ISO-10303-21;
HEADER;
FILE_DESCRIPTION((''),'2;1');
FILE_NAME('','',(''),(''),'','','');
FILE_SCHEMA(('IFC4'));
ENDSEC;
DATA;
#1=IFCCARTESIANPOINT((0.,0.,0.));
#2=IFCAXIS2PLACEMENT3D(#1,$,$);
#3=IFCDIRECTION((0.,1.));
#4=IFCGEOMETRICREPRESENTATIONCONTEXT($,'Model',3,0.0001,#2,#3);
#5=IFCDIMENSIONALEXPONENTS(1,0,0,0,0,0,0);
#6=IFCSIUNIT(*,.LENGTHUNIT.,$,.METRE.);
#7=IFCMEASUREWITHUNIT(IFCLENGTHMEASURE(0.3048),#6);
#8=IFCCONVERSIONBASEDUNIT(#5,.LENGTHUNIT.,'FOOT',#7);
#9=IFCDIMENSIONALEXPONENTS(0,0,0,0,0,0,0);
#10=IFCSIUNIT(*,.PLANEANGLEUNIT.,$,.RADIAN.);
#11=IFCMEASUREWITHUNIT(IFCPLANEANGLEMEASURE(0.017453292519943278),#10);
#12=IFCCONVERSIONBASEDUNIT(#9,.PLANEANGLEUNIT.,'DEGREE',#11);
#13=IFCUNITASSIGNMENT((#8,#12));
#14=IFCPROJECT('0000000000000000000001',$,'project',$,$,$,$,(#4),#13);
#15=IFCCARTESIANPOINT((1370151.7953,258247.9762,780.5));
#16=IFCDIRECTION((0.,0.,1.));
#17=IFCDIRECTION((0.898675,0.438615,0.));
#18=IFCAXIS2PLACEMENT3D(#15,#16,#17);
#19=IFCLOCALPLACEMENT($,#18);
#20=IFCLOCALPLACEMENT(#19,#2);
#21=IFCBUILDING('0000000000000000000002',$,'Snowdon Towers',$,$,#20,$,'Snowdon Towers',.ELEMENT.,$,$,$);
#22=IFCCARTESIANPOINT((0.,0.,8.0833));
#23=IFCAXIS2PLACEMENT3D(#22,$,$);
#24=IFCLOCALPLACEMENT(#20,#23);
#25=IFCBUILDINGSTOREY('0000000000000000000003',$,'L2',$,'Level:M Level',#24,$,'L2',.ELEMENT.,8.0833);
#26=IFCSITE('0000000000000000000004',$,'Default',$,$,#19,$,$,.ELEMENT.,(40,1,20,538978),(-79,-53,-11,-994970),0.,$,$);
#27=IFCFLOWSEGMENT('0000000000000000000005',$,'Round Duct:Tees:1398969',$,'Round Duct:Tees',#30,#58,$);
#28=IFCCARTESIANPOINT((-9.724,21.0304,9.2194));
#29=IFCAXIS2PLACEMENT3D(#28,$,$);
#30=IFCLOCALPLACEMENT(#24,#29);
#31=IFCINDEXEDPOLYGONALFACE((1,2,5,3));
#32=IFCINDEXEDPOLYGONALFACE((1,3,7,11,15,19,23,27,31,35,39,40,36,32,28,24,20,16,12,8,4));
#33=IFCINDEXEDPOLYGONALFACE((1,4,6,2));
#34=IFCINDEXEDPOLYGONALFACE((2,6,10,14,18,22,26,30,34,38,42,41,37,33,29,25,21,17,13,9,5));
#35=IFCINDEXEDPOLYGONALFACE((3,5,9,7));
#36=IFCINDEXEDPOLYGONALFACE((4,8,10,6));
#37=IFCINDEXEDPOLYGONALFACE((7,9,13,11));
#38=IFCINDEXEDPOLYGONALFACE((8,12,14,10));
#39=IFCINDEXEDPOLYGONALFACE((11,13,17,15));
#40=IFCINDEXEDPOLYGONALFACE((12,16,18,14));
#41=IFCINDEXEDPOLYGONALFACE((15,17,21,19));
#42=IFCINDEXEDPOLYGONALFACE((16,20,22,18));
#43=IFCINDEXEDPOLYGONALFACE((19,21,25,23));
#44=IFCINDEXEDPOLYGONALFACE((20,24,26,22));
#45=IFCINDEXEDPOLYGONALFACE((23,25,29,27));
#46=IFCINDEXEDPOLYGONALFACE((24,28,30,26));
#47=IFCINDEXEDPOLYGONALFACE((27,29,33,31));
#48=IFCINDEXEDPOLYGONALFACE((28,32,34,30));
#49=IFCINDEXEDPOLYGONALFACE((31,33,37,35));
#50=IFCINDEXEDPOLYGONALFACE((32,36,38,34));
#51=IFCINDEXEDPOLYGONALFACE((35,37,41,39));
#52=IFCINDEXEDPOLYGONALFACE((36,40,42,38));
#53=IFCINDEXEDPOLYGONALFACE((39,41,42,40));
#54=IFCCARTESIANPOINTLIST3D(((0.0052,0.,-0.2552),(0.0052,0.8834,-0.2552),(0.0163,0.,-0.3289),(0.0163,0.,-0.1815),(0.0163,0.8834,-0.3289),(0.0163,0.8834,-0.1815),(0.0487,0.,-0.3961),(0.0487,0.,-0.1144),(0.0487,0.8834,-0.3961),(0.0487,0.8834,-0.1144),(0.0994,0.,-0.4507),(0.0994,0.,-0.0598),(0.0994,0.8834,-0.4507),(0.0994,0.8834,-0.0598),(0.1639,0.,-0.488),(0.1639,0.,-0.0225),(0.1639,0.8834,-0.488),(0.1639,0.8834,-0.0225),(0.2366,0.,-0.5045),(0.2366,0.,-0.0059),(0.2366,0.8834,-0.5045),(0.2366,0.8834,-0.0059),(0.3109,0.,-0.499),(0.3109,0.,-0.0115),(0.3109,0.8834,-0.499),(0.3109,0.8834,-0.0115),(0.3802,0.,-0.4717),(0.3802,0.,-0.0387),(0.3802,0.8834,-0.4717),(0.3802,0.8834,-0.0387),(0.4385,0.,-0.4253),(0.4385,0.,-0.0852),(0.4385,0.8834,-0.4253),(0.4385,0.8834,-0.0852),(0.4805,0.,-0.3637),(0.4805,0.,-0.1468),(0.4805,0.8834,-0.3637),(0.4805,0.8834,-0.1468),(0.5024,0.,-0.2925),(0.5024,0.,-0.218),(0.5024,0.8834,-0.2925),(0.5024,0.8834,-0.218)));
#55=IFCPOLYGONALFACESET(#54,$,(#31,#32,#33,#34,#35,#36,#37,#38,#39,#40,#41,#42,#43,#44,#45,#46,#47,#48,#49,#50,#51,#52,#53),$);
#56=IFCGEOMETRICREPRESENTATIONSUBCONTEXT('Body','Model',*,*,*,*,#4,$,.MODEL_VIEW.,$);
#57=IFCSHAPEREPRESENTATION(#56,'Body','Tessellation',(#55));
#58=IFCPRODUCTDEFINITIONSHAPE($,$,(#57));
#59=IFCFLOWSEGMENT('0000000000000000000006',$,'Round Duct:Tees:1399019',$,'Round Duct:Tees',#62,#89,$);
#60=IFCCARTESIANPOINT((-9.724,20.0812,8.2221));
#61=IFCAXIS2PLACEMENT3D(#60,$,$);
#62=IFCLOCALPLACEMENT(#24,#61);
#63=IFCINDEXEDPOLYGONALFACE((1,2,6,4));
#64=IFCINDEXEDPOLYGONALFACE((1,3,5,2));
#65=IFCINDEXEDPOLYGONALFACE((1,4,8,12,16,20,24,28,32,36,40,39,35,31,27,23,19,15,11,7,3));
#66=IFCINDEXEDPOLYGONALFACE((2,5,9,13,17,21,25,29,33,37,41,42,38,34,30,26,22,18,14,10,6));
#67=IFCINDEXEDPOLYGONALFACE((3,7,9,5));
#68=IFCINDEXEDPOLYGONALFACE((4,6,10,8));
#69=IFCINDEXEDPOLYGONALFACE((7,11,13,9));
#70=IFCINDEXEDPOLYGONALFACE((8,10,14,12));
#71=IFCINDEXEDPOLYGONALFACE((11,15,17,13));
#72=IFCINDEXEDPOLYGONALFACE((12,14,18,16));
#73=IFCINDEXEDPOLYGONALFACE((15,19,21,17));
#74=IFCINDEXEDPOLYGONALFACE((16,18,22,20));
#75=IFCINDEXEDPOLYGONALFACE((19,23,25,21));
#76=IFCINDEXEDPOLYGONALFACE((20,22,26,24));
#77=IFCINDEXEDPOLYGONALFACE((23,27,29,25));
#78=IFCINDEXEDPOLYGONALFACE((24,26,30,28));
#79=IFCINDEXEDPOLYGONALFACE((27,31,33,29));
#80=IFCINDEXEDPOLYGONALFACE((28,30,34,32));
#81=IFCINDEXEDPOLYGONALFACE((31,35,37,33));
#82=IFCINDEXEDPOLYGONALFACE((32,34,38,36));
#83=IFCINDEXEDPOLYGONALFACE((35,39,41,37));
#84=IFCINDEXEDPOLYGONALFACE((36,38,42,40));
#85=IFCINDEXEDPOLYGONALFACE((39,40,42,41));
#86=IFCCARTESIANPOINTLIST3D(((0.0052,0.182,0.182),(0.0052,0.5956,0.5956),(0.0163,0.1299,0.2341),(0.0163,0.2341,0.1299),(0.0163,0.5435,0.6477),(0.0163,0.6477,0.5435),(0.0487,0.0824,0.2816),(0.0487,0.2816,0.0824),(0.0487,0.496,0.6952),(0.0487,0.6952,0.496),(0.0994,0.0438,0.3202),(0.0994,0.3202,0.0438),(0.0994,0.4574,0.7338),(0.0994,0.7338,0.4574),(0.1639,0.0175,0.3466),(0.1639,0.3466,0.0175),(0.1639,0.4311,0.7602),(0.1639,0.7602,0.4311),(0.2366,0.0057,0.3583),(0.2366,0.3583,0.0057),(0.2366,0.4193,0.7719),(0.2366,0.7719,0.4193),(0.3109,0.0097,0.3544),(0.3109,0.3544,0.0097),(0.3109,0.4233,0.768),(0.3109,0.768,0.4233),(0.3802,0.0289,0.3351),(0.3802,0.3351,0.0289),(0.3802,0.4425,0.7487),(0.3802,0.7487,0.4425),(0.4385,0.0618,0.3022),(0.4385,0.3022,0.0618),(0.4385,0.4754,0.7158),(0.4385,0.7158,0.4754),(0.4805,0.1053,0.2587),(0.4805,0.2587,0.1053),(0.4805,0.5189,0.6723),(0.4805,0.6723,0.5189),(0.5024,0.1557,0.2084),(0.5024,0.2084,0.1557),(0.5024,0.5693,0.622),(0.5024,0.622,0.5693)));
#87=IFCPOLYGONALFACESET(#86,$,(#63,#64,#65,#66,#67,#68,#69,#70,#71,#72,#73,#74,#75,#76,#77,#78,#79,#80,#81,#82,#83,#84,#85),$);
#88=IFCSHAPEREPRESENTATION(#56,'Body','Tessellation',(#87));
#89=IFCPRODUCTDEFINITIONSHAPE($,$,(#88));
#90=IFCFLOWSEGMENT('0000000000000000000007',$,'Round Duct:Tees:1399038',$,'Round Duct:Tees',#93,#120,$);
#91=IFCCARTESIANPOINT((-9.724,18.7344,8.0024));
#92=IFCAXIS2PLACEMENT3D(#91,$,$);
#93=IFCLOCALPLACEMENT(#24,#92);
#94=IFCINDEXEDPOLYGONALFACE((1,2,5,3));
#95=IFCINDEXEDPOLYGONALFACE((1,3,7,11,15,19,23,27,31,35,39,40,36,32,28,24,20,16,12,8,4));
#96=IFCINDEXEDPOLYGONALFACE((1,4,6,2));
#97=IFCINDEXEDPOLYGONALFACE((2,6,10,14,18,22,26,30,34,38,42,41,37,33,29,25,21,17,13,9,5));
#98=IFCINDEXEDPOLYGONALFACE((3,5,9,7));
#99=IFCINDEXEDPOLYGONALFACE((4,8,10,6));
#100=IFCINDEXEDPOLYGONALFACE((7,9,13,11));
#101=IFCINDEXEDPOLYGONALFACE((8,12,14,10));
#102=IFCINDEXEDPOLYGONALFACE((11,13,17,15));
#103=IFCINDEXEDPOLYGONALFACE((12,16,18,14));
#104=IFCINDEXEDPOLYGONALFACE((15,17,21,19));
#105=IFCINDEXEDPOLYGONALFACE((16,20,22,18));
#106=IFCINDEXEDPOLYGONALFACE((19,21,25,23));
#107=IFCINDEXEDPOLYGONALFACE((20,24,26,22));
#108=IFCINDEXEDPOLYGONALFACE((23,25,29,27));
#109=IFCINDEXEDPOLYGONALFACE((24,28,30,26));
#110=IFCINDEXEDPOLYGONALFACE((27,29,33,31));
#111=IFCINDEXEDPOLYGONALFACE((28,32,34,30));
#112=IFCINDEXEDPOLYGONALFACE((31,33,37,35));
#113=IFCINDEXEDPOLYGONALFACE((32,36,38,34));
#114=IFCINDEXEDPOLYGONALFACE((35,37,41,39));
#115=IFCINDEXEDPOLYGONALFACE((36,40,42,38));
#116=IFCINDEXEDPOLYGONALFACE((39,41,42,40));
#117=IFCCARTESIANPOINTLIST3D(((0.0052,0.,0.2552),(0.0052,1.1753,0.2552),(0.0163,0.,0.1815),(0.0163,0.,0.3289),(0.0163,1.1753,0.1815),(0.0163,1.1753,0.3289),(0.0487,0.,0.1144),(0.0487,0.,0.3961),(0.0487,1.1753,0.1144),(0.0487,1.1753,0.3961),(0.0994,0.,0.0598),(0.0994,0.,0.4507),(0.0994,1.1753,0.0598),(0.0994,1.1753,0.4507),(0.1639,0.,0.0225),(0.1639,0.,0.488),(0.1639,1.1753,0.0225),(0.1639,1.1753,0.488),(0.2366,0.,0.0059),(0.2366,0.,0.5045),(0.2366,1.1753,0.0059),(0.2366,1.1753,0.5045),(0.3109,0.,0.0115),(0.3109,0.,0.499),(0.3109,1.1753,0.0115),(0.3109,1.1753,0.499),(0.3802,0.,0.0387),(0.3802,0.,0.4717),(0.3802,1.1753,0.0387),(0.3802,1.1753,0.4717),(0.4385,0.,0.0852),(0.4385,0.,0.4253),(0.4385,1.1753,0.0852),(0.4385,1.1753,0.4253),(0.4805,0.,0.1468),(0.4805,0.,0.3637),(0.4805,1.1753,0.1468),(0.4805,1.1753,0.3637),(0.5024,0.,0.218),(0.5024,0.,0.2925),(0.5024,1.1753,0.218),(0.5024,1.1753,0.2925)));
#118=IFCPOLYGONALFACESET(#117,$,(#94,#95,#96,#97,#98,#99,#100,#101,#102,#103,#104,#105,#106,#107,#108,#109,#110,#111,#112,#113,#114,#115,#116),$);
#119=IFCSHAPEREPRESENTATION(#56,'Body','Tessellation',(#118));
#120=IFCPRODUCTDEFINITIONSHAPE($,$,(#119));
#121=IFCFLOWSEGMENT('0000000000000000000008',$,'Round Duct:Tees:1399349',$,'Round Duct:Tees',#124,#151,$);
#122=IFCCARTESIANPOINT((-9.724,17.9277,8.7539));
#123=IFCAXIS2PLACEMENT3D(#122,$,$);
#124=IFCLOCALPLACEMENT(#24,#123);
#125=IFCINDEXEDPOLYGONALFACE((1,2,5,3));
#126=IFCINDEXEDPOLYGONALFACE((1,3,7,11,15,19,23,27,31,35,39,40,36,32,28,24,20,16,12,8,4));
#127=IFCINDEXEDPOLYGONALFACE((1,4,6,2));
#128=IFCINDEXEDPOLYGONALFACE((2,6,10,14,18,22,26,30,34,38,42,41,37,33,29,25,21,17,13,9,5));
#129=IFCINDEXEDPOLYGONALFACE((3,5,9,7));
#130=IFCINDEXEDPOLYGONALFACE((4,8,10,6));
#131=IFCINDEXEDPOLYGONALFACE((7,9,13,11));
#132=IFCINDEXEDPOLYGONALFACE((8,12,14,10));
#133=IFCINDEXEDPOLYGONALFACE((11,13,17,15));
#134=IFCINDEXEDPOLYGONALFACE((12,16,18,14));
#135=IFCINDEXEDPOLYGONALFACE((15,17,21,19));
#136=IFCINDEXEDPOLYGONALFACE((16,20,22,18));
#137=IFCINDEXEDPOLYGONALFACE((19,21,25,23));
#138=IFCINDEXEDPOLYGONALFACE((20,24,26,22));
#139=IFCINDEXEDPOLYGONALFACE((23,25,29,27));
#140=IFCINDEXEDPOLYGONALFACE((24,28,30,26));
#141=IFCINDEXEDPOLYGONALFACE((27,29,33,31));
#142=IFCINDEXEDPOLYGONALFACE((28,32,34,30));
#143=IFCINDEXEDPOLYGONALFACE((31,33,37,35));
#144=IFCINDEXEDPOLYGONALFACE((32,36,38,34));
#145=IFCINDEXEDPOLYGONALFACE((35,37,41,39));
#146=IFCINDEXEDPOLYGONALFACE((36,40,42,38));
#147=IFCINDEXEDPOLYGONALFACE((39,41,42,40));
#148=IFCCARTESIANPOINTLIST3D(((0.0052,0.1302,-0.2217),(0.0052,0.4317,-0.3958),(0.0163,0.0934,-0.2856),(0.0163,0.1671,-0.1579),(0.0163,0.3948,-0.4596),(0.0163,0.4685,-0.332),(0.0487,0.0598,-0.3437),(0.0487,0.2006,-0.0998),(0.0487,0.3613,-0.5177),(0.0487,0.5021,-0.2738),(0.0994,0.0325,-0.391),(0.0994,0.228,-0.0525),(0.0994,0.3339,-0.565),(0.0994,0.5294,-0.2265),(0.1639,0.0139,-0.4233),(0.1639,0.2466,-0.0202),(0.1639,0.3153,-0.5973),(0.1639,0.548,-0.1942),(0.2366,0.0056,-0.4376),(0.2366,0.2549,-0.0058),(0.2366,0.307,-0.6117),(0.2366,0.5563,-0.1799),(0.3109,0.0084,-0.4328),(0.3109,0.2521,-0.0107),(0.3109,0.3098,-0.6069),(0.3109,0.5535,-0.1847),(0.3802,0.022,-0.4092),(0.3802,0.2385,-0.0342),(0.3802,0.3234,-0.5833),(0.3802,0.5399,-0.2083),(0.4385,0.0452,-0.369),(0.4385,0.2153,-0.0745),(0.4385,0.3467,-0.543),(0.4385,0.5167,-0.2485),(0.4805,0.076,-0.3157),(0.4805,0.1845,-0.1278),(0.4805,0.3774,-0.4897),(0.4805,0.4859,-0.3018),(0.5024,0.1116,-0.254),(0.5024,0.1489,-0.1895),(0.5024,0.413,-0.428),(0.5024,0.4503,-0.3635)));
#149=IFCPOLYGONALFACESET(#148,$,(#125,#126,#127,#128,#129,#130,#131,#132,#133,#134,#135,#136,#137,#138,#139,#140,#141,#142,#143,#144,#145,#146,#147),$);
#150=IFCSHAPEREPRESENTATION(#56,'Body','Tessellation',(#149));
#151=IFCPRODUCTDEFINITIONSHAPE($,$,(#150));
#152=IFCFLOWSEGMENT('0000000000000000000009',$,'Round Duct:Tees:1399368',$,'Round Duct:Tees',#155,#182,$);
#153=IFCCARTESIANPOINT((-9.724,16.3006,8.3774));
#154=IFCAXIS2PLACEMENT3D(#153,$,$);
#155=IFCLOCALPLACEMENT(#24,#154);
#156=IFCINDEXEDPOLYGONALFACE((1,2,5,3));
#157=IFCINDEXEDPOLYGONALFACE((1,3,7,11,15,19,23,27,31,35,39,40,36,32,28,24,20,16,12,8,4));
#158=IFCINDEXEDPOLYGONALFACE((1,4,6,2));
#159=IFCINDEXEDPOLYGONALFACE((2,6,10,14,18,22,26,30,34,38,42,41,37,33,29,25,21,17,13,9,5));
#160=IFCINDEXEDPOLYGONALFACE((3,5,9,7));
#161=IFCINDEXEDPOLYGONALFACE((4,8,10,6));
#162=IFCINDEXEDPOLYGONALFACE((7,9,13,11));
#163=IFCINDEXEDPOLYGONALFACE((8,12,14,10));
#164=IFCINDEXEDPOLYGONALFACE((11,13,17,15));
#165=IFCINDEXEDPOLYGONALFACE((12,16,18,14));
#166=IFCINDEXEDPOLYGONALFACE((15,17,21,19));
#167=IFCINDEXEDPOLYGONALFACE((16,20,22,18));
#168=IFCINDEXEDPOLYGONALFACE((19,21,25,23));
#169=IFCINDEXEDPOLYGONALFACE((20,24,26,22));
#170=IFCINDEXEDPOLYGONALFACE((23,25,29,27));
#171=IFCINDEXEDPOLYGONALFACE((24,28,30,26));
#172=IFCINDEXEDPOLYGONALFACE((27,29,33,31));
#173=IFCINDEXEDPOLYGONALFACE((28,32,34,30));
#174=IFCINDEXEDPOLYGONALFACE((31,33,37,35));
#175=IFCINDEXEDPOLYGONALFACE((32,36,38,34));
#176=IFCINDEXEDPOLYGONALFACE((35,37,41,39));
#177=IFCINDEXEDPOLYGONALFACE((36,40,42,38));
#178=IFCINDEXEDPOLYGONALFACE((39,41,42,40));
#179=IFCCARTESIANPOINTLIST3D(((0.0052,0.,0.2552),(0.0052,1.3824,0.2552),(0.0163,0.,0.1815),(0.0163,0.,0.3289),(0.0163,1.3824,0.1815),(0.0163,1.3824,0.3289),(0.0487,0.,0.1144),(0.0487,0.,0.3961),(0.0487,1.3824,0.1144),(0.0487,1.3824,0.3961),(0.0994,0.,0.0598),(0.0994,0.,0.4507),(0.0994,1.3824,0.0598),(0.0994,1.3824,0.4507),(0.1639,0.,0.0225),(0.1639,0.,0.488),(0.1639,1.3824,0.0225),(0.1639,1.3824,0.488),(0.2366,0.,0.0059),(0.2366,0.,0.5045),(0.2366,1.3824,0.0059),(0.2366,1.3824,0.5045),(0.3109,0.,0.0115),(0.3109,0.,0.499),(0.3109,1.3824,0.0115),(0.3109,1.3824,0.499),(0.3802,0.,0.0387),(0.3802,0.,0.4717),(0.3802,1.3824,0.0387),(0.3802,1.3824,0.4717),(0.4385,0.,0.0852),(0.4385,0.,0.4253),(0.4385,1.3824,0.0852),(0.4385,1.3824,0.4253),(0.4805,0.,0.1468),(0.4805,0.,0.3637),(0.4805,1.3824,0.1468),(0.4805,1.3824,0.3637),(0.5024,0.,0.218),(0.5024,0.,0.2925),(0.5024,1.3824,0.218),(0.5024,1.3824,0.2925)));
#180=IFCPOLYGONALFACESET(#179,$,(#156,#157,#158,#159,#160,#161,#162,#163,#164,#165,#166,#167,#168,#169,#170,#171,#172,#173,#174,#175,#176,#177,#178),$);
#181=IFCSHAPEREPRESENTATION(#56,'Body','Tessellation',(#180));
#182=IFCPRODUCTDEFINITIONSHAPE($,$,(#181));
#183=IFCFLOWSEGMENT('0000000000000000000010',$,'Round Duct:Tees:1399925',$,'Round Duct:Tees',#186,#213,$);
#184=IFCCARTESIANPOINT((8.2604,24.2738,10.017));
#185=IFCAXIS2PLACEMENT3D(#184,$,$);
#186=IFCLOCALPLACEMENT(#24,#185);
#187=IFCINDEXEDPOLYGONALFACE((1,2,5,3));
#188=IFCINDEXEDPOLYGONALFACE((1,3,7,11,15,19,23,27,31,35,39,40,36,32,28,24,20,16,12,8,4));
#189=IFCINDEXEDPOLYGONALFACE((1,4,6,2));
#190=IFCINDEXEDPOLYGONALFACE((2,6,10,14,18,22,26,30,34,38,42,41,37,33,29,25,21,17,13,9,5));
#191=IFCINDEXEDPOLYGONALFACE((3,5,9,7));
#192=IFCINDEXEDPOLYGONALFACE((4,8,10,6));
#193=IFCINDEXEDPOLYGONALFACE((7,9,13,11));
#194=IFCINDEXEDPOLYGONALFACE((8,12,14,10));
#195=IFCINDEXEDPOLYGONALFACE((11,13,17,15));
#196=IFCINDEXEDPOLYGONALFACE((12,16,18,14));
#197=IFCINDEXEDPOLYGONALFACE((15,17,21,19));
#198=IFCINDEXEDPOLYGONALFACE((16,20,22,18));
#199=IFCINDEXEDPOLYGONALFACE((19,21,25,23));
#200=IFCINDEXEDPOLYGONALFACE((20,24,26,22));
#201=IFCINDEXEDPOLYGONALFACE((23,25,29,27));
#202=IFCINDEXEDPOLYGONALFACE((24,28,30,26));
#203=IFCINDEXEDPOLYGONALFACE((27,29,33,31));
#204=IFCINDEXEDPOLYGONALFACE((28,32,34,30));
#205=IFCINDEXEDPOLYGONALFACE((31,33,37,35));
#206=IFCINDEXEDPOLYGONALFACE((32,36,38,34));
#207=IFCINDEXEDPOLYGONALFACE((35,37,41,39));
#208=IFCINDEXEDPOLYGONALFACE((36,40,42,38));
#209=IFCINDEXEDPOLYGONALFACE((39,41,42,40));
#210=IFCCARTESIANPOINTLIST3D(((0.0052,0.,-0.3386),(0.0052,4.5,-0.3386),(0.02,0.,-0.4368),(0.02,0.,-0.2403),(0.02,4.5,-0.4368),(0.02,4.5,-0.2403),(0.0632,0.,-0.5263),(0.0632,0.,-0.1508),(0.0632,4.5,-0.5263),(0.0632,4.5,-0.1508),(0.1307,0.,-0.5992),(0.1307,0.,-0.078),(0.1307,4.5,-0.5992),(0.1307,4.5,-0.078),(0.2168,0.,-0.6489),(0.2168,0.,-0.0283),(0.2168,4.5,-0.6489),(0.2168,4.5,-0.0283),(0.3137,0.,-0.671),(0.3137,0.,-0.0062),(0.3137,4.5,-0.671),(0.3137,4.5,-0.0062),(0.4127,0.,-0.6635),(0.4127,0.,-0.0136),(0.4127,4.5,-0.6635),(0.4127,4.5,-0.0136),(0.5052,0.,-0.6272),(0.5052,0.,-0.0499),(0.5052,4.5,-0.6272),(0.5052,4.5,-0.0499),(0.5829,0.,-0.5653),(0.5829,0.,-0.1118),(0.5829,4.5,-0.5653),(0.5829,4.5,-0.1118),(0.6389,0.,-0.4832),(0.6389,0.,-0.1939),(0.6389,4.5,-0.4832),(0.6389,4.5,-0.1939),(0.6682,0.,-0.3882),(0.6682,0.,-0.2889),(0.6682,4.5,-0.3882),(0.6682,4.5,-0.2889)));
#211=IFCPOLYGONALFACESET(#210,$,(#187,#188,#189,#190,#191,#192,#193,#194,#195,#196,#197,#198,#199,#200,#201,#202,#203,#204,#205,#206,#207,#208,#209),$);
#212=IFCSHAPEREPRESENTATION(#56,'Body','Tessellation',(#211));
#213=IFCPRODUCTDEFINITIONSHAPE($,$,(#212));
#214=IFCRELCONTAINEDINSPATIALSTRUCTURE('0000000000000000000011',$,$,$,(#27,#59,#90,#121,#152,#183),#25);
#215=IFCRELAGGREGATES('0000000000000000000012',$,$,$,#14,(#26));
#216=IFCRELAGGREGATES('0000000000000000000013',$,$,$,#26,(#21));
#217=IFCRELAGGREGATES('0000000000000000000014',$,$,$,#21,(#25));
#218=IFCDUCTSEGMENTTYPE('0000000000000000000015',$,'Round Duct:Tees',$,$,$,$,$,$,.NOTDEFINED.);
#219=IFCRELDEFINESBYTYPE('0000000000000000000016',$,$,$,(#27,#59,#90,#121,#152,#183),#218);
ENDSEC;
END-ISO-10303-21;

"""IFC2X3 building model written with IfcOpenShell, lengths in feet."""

from ifc_helpers import new_model, entity, si_unit, converted_unit, direction, frame, frame_2d, origin, place, context, subcontext, project, spatial, circle, extrude, type_object, element, save


model = new_model("IFC2X3")

# Units and contexts
model_context = context("Model", 3, precision=0.0001, world=origin(), true_north=direction((0.0, 1.0)))
body_context = subcontext(model_context, "Body", "Model", "MODEL_VIEW")
ifc_project = project(units=[converted_unit("LENGTHUNIT", "FOOT", entity("IfcLengthMeasure", 0.3048), si_unit("LENGTHUNIT", "METRE"), dimensions=[1, 0, 0, 0, 0, 0, 0]), converted_unit("PLANEANGLEUNIT", "DEGREE", entity("IfcPlaneAngleMeasure", 0.017453292519943278), si_unit("PLANEANGLEUNIT", "RADIAN"), dimensions=[0, 0, 0, 0, 0, 0, 0])], contexts=[model_context])

# Site, building, storey
site_placement = place(None, frame((1370151.7953, 258247.9762, 780.5), z_axis=(0.0, 0.0, 1.0), x_axis=(0.898675, 0.438615, 0.0)))
site = spatial("IfcSite", under=ifc_project, at=site_placement, Name="Default", CompositionType="ELEMENT", RefLatitude=(40, 1, 20, 538978), RefLongitude=(-79, -53, -11, -994970), RefElevation=0.0)
building_placement = place(site_placement, origin())
building = spatial("IfcBuilding", under=site, at=building_placement, Name="Snowdon Towers", LongName="Snowdon Towers", CompositionType="ELEMENT")
storey_placement = place(building_placement, frame((0.0, 0.0, 8.0833)))
storey = spatial("IfcBuildingStorey", under=building, at=storey_placement, Name="L2", ObjectType="Level:M Level", LongName="L2", CompositionType="ELEMENT", Elevation=8.0833)

# Flow segments
duct_segment_type = type_object("IfcDuctSegmentType", Name="Round Duct:Tees", PredefinedType="NOTDEFINED")
flow_segment_1_placement = place(storey_placement, frame((-9.724, 21.0304, 9.2194)))
element("IfcFlowSegment", 1, at=flow_segment_1_placement, inside=storey, type_object=duct_segment_type, Name="Round Duct:Tees:1398969", ObjectType="Round Duct:Tees", context=body_context, shape_type="SweptSolid", body=[
    extrude(circle(Radius=0.25, at=frame_2d((0.0, 0.0), x_axis=(1.0, 0.0))), frame((0.2552, 0.0, -0.2552), z_axis=(0.0, 1.0, 0.0), x_axis=(-1.0, 0.0, 0.0)), (0.0, 0.0, 1.0), 0.8834),
])
flow_segment_2_placement = place(storey_placement, frame((-9.724, 20.0812, 8.2221)))
element("IfcFlowSegment", 2, at=flow_segment_2_placement, inside=storey, type_object=duct_segment_type, Name="Round Duct:Tees:1399019", ObjectType="Round Duct:Tees", context=body_context, shape_type="SweptSolid", body=[
    extrude(circle(Radius=0.25, at=frame_2d((0.0, 0.0), x_axis=(1.0, 0.0))), frame((0.2552, 0.182, 0.182), z_axis=(0.0, 0.707107, 0.707107), x_axis=(-1.0, 0.0, 0.0)), (0.0, 0.0, 1.0), 0.5849),
])
flow_segment_3_placement = place(storey_placement, frame((-9.724, 18.7344, 8.0024)))
element("IfcFlowSegment", 3, at=flow_segment_3_placement, inside=storey, type_object=duct_segment_type, Name="Round Duct:Tees:1399038", ObjectType="Round Duct:Tees", context=body_context, shape_type="SweptSolid", body=[
    extrude(circle(Radius=0.25, at=frame_2d((0.0, 0.0), x_axis=(1.0, 0.0))), frame((0.2552, 0.0, 0.2552), z_axis=(0.0, 1.0, 0.0), x_axis=(-1.0, 0.0, 0.0)), (0.0, 0.0, 1.0), 1.1753),
])
flow_segment_4_placement = place(storey_placement, frame((-9.724, 17.9277, 8.7539)))
element("IfcFlowSegment", 4, at=flow_segment_4_placement, inside=storey, type_object=duct_segment_type, Name="Round Duct:Tees:1399349", ObjectType="Round Duct:Tees", context=body_context, shape_type="SweptSolid", body=[
    extrude(circle(Radius=0.25, at=frame_2d((0.0, 0.0), x_axis=(1.0, 0.0))), frame((0.2552, 0.1302, -0.2217), z_axis=(0.0, 0.866025, -0.5), x_axis=(-1.0, 0.0, 0.0)), (0.0, 0.0, 1.0), 0.3481),
])
flow_segment_5_placement = place(storey_placement, frame((-9.724, 16.3006, 8.3774)))
element("IfcFlowSegment", 5, at=flow_segment_5_placement, inside=storey, type_object=duct_segment_type, Name="Round Duct:Tees:1399368", ObjectType="Round Duct:Tees", context=body_context, shape_type="SweptSolid", body=[
    extrude(circle(Radius=0.25, at=frame_2d((0.0, 0.0), x_axis=(1.0, 0.0))), frame((0.2552, 0.0, 0.2552), z_axis=(0.0, 1.0, 0.0), x_axis=(-1.0, 0.0, 0.0)), (0.0, 0.0, 1.0), 1.3824),
])
flow_segment_6_placement = place(storey_placement, frame((8.2604, 24.2738, 10.017)))
element("IfcFlowSegment", 6, at=flow_segment_6_placement, inside=storey, type_object=duct_segment_type, Name="Round Duct:Tees:1399925", ObjectType="Round Duct:Tees", context=body_context, shape_type="SweptSolid", body=[
    extrude(circle(Radius=0.3333, at=frame_2d((0.0, 0.0), x_axis=(1.0, 0.0))), frame((0.3386, 0.0, -0.3386), z_axis=(0.0, 1.0, 0.0), x_axis=(-1.0, 0.0, 0.0)), (0.0, 0.0, 1.0), 4.5),
])

save(model, "model.ifc")
